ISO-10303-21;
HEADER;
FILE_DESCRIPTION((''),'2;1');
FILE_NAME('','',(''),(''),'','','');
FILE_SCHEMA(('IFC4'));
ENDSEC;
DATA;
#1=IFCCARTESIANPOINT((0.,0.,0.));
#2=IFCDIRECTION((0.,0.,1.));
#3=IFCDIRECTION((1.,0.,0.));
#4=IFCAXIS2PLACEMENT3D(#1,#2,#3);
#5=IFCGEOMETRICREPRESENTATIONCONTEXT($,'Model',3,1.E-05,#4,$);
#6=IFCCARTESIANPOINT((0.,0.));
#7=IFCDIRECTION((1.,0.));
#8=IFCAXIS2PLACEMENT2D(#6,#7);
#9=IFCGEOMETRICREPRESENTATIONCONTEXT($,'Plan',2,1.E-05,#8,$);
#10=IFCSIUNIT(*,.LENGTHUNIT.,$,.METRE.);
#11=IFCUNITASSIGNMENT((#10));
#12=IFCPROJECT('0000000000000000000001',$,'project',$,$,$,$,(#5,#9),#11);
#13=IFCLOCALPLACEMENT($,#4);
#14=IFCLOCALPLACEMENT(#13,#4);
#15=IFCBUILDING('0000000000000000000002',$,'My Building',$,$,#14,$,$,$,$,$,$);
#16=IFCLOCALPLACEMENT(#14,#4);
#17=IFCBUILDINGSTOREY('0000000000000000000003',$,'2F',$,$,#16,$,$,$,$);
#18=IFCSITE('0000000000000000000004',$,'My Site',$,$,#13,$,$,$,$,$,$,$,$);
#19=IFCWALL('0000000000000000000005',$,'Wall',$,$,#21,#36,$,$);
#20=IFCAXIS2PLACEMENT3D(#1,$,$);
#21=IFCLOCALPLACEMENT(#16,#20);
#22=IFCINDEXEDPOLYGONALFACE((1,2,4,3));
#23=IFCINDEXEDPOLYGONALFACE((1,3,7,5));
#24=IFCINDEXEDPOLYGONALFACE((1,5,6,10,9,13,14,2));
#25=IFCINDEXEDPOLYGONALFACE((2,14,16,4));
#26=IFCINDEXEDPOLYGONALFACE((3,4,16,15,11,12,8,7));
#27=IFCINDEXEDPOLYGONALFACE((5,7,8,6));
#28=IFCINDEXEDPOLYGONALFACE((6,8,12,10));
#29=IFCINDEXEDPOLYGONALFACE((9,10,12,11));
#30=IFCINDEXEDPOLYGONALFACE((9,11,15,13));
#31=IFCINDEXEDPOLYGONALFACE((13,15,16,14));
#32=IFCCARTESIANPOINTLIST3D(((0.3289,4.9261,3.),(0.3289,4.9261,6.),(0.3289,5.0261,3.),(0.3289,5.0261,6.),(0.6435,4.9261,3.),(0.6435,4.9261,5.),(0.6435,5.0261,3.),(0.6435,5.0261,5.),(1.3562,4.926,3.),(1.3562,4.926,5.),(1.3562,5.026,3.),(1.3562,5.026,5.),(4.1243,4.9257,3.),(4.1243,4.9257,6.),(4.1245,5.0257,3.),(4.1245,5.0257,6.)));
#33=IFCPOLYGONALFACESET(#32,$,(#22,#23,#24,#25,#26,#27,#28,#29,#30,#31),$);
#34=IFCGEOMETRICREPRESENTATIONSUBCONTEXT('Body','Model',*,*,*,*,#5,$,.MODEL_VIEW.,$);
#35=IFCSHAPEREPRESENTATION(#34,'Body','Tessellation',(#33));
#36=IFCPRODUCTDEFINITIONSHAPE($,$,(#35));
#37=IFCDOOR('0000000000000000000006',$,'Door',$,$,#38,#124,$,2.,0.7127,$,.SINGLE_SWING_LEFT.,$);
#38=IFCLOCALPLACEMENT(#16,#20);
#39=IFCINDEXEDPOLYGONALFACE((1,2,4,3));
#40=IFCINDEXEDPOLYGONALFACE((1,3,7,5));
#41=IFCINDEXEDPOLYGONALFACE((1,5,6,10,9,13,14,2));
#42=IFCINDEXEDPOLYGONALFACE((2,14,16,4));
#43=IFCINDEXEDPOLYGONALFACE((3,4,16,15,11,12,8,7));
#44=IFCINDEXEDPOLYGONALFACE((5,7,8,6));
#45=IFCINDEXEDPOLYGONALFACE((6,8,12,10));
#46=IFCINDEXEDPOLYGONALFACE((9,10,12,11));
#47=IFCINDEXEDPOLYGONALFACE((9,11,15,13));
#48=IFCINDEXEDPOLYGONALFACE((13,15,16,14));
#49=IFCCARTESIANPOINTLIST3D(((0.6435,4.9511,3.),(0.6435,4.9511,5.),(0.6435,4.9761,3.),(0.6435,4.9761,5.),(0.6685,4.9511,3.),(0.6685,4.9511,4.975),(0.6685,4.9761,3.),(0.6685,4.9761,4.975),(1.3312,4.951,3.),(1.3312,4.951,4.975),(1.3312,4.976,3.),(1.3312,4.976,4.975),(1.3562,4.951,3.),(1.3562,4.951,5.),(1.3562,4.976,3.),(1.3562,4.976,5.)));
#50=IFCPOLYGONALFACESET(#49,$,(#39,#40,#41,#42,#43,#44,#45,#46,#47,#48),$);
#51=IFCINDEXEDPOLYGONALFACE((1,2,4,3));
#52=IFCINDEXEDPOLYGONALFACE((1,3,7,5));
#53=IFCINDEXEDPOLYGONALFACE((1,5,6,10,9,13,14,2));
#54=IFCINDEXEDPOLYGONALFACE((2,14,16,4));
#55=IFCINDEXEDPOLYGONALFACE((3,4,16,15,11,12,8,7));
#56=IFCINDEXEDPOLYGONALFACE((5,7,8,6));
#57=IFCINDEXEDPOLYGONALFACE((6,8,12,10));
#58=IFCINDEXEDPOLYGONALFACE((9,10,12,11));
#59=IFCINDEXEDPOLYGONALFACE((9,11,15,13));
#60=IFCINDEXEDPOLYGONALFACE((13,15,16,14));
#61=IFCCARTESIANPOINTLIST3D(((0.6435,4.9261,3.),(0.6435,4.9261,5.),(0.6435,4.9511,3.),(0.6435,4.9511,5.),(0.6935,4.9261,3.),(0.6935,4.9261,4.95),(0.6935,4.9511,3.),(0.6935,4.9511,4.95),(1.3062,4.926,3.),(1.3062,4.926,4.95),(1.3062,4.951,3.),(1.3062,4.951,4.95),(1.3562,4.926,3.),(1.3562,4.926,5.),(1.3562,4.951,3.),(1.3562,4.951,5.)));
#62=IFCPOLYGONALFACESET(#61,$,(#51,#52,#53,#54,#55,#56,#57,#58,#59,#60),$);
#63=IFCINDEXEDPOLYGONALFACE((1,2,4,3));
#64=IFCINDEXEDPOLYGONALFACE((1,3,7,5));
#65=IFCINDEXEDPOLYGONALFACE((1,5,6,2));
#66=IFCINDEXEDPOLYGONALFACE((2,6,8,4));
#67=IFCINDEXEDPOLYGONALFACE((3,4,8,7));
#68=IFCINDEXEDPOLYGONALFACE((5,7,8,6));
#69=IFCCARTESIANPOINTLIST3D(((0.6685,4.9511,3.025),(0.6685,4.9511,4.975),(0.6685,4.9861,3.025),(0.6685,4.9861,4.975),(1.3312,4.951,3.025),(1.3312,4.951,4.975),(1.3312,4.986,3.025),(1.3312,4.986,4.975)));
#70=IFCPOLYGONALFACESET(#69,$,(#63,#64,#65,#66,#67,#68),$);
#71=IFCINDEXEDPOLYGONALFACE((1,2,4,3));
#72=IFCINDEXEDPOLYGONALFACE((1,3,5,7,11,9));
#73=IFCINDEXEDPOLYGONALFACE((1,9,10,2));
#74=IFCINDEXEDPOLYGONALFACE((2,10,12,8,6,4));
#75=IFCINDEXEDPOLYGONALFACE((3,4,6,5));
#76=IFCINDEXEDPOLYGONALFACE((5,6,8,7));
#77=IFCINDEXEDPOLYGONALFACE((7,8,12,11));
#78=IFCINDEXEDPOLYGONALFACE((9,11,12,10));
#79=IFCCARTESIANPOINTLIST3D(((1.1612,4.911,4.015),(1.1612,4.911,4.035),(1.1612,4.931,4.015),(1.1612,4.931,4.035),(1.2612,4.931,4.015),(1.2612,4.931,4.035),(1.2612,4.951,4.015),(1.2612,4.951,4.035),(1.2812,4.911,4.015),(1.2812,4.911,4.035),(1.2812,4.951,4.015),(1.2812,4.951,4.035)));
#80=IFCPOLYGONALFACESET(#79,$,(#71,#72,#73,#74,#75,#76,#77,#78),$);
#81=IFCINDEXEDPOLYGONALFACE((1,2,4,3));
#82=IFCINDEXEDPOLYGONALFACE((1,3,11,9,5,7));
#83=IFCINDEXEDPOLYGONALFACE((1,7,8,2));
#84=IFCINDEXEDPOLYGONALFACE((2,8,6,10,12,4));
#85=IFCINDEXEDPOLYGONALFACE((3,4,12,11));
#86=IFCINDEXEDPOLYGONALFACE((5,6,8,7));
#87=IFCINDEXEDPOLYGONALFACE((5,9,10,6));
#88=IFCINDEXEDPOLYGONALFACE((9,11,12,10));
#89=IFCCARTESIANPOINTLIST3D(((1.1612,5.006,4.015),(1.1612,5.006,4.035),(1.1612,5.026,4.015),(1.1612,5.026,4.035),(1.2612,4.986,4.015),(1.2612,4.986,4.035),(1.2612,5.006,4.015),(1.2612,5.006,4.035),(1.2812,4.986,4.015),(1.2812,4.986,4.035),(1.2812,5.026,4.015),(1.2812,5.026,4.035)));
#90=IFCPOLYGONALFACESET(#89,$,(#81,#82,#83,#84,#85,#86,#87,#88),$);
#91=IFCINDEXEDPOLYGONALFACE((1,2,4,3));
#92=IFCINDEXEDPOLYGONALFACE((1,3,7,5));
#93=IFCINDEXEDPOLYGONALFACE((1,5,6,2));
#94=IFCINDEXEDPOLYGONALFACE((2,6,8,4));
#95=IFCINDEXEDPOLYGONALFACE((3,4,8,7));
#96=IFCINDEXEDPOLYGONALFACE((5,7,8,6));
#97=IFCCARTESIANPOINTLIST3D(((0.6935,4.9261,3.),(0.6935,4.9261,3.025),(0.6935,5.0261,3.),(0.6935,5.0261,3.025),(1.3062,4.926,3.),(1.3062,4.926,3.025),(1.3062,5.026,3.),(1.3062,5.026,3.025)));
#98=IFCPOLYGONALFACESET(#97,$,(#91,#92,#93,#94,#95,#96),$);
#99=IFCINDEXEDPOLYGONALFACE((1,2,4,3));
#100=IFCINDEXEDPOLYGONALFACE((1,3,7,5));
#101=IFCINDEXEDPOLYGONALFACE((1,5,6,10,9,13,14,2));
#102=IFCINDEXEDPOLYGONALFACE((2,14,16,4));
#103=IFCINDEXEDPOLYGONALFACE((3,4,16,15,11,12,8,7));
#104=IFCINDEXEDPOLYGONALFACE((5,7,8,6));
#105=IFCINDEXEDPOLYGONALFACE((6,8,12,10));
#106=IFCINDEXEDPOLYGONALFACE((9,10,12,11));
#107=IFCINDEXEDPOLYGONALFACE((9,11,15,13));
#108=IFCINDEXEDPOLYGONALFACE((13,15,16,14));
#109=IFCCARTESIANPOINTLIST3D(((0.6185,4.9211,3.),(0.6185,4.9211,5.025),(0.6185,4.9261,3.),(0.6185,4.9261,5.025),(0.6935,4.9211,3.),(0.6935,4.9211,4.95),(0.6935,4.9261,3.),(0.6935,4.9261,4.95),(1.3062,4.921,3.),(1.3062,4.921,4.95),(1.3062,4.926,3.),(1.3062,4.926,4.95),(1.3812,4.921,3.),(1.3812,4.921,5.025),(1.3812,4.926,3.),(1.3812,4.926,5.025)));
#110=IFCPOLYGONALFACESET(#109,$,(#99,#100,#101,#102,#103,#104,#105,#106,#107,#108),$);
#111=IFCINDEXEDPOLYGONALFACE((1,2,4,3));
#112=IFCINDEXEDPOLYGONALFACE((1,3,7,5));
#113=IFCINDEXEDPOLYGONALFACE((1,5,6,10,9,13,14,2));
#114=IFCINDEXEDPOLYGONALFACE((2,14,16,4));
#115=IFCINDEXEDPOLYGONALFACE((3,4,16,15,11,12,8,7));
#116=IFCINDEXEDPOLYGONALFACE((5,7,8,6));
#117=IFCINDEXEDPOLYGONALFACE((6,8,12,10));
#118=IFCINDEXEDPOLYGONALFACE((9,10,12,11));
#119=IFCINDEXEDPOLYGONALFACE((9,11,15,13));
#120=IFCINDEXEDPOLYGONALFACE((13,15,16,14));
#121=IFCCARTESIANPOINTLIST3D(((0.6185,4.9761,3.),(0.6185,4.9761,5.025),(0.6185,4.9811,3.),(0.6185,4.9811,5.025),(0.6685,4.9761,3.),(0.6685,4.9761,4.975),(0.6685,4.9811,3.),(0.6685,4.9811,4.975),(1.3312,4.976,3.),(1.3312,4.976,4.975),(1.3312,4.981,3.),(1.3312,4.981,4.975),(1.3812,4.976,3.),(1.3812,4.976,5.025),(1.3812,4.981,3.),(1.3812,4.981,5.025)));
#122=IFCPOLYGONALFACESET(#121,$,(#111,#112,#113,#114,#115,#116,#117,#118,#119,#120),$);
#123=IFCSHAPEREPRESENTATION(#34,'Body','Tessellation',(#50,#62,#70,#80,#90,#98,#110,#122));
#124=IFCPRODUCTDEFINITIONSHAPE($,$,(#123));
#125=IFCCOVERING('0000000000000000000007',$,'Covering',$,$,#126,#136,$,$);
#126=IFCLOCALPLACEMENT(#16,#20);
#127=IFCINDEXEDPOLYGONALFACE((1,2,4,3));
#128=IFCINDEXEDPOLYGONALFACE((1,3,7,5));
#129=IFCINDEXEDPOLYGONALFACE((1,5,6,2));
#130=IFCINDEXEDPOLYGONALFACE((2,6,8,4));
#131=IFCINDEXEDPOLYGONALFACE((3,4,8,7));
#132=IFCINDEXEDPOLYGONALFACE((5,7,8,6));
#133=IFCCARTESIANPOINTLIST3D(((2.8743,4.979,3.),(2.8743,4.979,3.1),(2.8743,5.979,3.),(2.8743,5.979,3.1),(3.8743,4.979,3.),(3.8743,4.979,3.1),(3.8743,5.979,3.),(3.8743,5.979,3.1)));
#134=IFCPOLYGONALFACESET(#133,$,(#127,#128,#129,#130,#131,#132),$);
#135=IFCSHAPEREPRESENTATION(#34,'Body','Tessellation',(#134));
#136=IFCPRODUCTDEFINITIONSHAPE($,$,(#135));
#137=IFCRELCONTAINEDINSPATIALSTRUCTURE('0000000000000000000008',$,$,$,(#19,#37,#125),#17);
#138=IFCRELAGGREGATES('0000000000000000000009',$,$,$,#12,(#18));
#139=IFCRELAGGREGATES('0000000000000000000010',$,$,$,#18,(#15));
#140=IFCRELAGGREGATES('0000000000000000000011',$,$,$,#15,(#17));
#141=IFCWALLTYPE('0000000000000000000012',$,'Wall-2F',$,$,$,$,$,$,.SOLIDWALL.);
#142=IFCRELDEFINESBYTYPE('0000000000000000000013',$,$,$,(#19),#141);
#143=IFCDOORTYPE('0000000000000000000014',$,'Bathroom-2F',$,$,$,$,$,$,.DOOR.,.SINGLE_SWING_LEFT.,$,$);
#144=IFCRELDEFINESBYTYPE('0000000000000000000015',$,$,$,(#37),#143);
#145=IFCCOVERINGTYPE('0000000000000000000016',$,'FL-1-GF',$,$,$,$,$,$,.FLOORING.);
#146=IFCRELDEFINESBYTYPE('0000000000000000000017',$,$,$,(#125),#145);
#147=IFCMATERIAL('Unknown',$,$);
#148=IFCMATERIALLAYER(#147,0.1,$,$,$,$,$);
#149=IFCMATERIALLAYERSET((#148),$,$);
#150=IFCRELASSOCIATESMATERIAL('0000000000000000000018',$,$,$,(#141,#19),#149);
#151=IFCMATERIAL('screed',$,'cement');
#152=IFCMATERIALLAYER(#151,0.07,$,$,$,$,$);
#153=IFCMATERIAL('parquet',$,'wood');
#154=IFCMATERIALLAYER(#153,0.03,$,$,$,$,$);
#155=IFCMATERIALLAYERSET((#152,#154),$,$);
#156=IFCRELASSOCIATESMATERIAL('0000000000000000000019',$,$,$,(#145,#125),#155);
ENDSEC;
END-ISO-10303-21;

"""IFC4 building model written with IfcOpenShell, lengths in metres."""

from ifc_helpers import new_model, entity, si_unit, frame, origin_with_axes, origin_2d_with_axis, place, context, subcontext, project, spatial, line, indexed_curve, outline, extrude, shape, source, transform, mapped, material, layer, layer_set, layer_usage, type_object, type_shapes, element, fill, save


model = new_model("IFC4")

# Units and contexts
model_context = context("Model", 3, precision=1e-05, world=origin_with_axes())
plan_context = context("Plan", 2, precision=1e-05, world=origin_2d_with_axis())
body_context_1 = subcontext(model_context, "Body", "Model", "MODEL_VIEW")
body_context_2 = subcontext(plan_context, "Body", "Plan", "PLAN_VIEW")
ifc_project = project(units=[si_unit("LENGTHUNIT", "METRE")], contexts=[model_context, plan_context])

# Site, building, storey
site_placement = place(None, origin_with_axes())
site = spatial("IfcSite", under=ifc_project, at=site_placement, Name="My Site")
building_placement = place(site_placement, origin_with_axes())
building = spatial("IfcBuilding", under=site, at=building_placement, Name="My Building")
storey_placement = place(building_placement, origin_with_axes())
storey = spatial("IfcBuildingStorey", under=building, at=storey_placement, Name="2F")

# Shared definitions
ifc_material_1 = material(Name="Unknown")

# Shared definitions
ifc_layer_1 = layer(ifc_material_1, 0.1)
ifc_layer_set_1 = layer_set([ifc_layer_1])
wall_type = type_object("IfcWallType", Name="Wall-2F", PredefinedType="SOLIDWALL", material=ifc_layer_set_1)

# Wall, opening, door
ifc_layer_usage_1 = layer_usage(ifc_layer_set_1, "AXIS2", "POSITIVE", 0.0)
wall_1_placement = place(storey_placement, frame((0.3289, 4.9261, 3.0), z_axis=(0.0, 0.0, 1.0), x_axis=(1.0, -0.000101, 0.0)))
wall_1 = element("IfcWall", 1, at=wall_1_placement, inside=storey, type_object=wall_type, material=ifc_layer_usage_1, Name="Wall", context=body_context_1, shape_type="SweptSolid", body=[
    extrude(outline(indexed_curve([(0.0, 0.0), (0.0, 0.1), (3.7955, 0.1), (3.7954, 0.0)], segments=[line(1, 2, 3, 4, 1)])), origin_with_axes(), (0.0, 0.0, 1.0), 3.0),
])
shared_shape_1 = source(origin_with_axes(), body_context_1, "Body", "SweptSolid", [
    extrude(outline(indexed_curve([(0.0, 0.0), (0.7127, 0.0), (0.7127, 2.0), (0.0, 2.0)], segments=[line(1, 2, 3, 4, 1)])), frame((0.0, -0.6, 0.0), z_axis=(0.0, -1.0, 0.0), x_axis=(1.0, 0.0, 0.0)), (0.0, 0.0, -1.0), 1.2),
])
opening_1_placement = place(wall_1_placement, frame((0.3146, 0.0, 0.0), z_axis=(0.0, 0.0, 1.0), x_axis=(1.0, 0.0, 0.0)))
opening_1 = element("IfcOpeningElement", 2, at=opening_1_placement, cuts=wall_1, PredefinedType="OPENING", context=body_context_1, shape_type="MappedRepresentation", body=[
    mapped(shared_shape_1, transform((0.0, 0.0, 0.0), x_axis=(1.0, 0.0, 0.0), y_axis=(0.0, 1.0, 0.0), z_axis=(0.0, 0.0, 1.0), scale=1.0)),
])
door_type = type_object("IfcDoorType", Name="Bathroom-2F", OperationType="SINGLE_SWING_LEFT", PredefinedType="DOOR")
shared_shape_2 = source(origin_with_axes(), body_context_1, "Body", "SweptSolid", [
    extrude(outline(indexed_curve([(0.0, 0.0), (0.0, 2.0), (0.7127, 2.0), (0.7127, 0.0), (0.6877, 0.0), (0.6877, 1.975), (0.025, 1.975), (0.025, 0.0)], segments=[line(1, 2, 3, 4, 5, 6, 7, 8, 1)])), frame((0.0, 0.025, 0.0), z_axis=(0.0, -1.0, 0.0), x_axis=(1.0, 0.0, 0.0)), (0.0, 0.0, -1.0), 0.025),
    extrude(outline(indexed_curve([(0.0, 0.0), (0.0, 2.0), (0.7127, 2.0), (0.7127, 0.0), (0.6627, 0.0), (0.6627, 1.95), (0.05, 1.95), (0.05, 0.0)], segments=[line(1, 2, 3, 4, 5, 6, 7, 8, 1)])), frame((0.0, 0.0, 0.0), z_axis=(0.0, -1.0, 0.0), x_axis=(1.0, 0.0, 0.0)), (0.0, 0.0, -1.0), 0.025),
    extrude(outline(indexed_curve([(0.0, 0.0), (0.6627, 0.0), (0.6627, 0.035), (0.0, 0.035)], segments=[line(1, 2, 3, 4, 1)])), frame((0.025, 0.025, 0.025), z_axis=(0.0, 0.0, 1.0), x_axis=(1.0, 0.0, 0.0)), (0.0, 0.0, 1.0), 1.95),
    extrude(outline(indexed_curve([(0.0, 0.0), (0.0, -0.04), (-0.12, -0.04), (-0.12, -0.02), (-0.02, -0.02), (-0.02, 0.0)], segments=[line(1, 2, 3, 4, 5, 6, 1)])), frame((0.6377, 0.025, 1.015), z_axis=(0.0, 0.0, 1.0), x_axis=(1.0, 0.0, 0.0)), (0.0, 0.0, 1.0), 0.02),
    extrude(outline(indexed_curve([(0.0, 0.0), (0.0, 0.04), (-0.12, 0.04), (-0.12, 0.02), (-0.02, 0.02), (-0.02, 0.0)], segments=[line(1, 2, 3, 4, 5, 6, 1)])), frame((0.6377, 0.06, 1.015), z_axis=(0.0, 0.0, 1.0), x_axis=(1.0, 0.0, 0.0)), (0.0, 0.0, 1.0), 0.02),
    extrude(outline(indexed_curve([(0.0, 0.0), (0.6127, 0.0), (0.6127, 0.1), (0.0, 0.1)], segments=[line(1, 2, 3, 4, 1)])), frame((0.05, 0.0, 0.0), z_axis=(0.0, 0.0, 1.0), x_axis=(1.0, 0.0, 0.0)), (0.0, 0.0, 1.0), 0.025),
    extrude(outline(indexed_curve([(0.0, 0.0), (0.0, 2.025), (0.7627, 2.025), (0.7627, 0.0), (0.6877, 0.0), (0.6877, 1.95), (0.075, 1.95), (0.075, 0.0)], segments=[line(1, 2, 3, 4, 5, 6, 7, 8, 1)])), frame((-0.025, -0.005, 0.0), z_axis=(0.0, -1.0, 0.0), x_axis=(1.0, 0.0, 0.0)), (0.0, 0.0, -1.0), 0.005),
    extrude(outline(indexed_curve([(0.0, 0.0), (0.0, 2.025), (0.7627, 2.025), (0.7627, 0.0), (0.7127, 0.0), (0.7127, 1.975), (0.05, 1.975), (0.05, 0.0)], segments=[line(1, 2, 3, 4, 5, 6, 7, 8, 1)])), frame((-0.025, 0.05, 0.0), z_axis=(0.0, -1.0, 0.0), x_axis=(1.0, 0.0, 0.0)), (0.0, 0.0, -1.0), 0.005),
])
shared_shape_3 = source(origin_with_axes(), body_context_2, "Body", "Curve2D", [
    entity("IfcIndexedPolyCurve", entity("IfcCartesianPointList2D", [[0.0, 0.0], [0.0, 0.05], [0.025, 0.05], [0.025, 0.025], [0.05, 0.025], [0.05, 0.0]]), [entity("IfcLineIndex", [1, 2, 3, 4, 5, 6, 1])]),
    entity("IfcIndexedPolyCurve", entity("IfcCartesianPointList2D", [[0.7127, 0.0], [0.7127, 0.05], [0.6877, 0.05], [0.6877, 0.025], [0.6627, 0.025], [0.6627, 0.0]]), [entity("IfcLineIndex", [1, 2, 3, 4, 5, 6, 1])]),
    entity("IfcTrimmedCurve", entity("IfcEllipse", entity("IfcAxis2Placement2D", entity("IfcCartesianPoint", [0.06, 0.05]), entity("IfcDirection", [1.0, 0.0])), 0.6277, 0.6627), [entity("IfcCartesianPoint", [0.6877, 0.05])], [entity("IfcCartesianPoint", [0.06, 0.7127])], True, "CARTESIAN"),
    entity("IfcIndexedPolyCurve", entity("IfcCartesianPointList2D", [[0.025, 0.05], [0.06, 0.05], [0.06, 0.7127], [0.025, 0.7127]]), [entity("IfcLineIndex", [1, 2, 3, 4, 1])]),
])
type_shapes(door_type, [shared_shape_2, shared_shape_3])
door_placement = place(opening_1_placement, frame((0.0, 0.0, 0.0), z_axis=(0.0, 0.0, 1.0), x_axis=(1.0, 0.0, 0.0)))
door = element("IfcDoor", 3, at=door_placement, inside=storey, type_object=door_type, Name="Door", OperationType="SINGLE_SWING_LEFT", OverallHeight=2.0, OverallWidth=0.7127, shapes=[
    shape(body_context_1, "Body", "MappedRepresentation", [mapped(shared_shape_2, transform((0.0, 0.0, 0.0), x_axis=(1.0, 0.0, 0.0), y_axis=(0.0, 1.0, 0.0), z_axis=(0.0, 0.0, 1.0), scale=1.0))]),
    shape(body_context_2, "Body", "MappedRepresentation", [mapped(shared_shape_3, transform((0.0, 0.0, 0.0), x_axis=(1.0, 0.0, 0.0), y_axis=(0.0, 1.0, 0.0), z_axis=(0.0, 0.0, 1.0), scale=1.0))]),
])
fill(opening_1, door)

# Covering
ifc_material_2 = material(Name="screed", Category="cement")
ifc_layer_2 = layer(ifc_material_2, 0.07)
ifc_material_3 = material(Name="parquet", Category="wood")
ifc_layer_3 = layer(ifc_material_3, 0.03)
ifc_layer_set_2 = layer_set([ifc_layer_2, ifc_layer_3])
ifc_layer_usage_2 = layer_usage(ifc_layer_set_2, "AXIS3", "POSITIVE", 0.0)
covering_type = type_object("IfcCoveringType", Name="FL-1-GF", PredefinedType="FLOORING", material=ifc_layer_set_2)
covering_1_placement = place(storey_placement, frame((2.8743, 4.979, 3.0), z_axis=(0.0, 0.0, 1.0), x_axis=(1.0, 0.0, 0.0)))
element("IfcCovering", 4, at=covering_1_placement, inside=storey, type_object=covering_type, material=ifc_layer_usage_2, Name="Covering", context=body_context_1, shape_type="SweptSolid", body=[
    extrude(outline(indexed_curve([(0.0, 0.0), (1.0, 0.0), (1.0, 1.0), (0.0, 1.0), (0.0, 0.0)])), origin_with_axes(), (0.0, 0.0, 1.0), 0.1),
])

save(model, "model.ifc")
